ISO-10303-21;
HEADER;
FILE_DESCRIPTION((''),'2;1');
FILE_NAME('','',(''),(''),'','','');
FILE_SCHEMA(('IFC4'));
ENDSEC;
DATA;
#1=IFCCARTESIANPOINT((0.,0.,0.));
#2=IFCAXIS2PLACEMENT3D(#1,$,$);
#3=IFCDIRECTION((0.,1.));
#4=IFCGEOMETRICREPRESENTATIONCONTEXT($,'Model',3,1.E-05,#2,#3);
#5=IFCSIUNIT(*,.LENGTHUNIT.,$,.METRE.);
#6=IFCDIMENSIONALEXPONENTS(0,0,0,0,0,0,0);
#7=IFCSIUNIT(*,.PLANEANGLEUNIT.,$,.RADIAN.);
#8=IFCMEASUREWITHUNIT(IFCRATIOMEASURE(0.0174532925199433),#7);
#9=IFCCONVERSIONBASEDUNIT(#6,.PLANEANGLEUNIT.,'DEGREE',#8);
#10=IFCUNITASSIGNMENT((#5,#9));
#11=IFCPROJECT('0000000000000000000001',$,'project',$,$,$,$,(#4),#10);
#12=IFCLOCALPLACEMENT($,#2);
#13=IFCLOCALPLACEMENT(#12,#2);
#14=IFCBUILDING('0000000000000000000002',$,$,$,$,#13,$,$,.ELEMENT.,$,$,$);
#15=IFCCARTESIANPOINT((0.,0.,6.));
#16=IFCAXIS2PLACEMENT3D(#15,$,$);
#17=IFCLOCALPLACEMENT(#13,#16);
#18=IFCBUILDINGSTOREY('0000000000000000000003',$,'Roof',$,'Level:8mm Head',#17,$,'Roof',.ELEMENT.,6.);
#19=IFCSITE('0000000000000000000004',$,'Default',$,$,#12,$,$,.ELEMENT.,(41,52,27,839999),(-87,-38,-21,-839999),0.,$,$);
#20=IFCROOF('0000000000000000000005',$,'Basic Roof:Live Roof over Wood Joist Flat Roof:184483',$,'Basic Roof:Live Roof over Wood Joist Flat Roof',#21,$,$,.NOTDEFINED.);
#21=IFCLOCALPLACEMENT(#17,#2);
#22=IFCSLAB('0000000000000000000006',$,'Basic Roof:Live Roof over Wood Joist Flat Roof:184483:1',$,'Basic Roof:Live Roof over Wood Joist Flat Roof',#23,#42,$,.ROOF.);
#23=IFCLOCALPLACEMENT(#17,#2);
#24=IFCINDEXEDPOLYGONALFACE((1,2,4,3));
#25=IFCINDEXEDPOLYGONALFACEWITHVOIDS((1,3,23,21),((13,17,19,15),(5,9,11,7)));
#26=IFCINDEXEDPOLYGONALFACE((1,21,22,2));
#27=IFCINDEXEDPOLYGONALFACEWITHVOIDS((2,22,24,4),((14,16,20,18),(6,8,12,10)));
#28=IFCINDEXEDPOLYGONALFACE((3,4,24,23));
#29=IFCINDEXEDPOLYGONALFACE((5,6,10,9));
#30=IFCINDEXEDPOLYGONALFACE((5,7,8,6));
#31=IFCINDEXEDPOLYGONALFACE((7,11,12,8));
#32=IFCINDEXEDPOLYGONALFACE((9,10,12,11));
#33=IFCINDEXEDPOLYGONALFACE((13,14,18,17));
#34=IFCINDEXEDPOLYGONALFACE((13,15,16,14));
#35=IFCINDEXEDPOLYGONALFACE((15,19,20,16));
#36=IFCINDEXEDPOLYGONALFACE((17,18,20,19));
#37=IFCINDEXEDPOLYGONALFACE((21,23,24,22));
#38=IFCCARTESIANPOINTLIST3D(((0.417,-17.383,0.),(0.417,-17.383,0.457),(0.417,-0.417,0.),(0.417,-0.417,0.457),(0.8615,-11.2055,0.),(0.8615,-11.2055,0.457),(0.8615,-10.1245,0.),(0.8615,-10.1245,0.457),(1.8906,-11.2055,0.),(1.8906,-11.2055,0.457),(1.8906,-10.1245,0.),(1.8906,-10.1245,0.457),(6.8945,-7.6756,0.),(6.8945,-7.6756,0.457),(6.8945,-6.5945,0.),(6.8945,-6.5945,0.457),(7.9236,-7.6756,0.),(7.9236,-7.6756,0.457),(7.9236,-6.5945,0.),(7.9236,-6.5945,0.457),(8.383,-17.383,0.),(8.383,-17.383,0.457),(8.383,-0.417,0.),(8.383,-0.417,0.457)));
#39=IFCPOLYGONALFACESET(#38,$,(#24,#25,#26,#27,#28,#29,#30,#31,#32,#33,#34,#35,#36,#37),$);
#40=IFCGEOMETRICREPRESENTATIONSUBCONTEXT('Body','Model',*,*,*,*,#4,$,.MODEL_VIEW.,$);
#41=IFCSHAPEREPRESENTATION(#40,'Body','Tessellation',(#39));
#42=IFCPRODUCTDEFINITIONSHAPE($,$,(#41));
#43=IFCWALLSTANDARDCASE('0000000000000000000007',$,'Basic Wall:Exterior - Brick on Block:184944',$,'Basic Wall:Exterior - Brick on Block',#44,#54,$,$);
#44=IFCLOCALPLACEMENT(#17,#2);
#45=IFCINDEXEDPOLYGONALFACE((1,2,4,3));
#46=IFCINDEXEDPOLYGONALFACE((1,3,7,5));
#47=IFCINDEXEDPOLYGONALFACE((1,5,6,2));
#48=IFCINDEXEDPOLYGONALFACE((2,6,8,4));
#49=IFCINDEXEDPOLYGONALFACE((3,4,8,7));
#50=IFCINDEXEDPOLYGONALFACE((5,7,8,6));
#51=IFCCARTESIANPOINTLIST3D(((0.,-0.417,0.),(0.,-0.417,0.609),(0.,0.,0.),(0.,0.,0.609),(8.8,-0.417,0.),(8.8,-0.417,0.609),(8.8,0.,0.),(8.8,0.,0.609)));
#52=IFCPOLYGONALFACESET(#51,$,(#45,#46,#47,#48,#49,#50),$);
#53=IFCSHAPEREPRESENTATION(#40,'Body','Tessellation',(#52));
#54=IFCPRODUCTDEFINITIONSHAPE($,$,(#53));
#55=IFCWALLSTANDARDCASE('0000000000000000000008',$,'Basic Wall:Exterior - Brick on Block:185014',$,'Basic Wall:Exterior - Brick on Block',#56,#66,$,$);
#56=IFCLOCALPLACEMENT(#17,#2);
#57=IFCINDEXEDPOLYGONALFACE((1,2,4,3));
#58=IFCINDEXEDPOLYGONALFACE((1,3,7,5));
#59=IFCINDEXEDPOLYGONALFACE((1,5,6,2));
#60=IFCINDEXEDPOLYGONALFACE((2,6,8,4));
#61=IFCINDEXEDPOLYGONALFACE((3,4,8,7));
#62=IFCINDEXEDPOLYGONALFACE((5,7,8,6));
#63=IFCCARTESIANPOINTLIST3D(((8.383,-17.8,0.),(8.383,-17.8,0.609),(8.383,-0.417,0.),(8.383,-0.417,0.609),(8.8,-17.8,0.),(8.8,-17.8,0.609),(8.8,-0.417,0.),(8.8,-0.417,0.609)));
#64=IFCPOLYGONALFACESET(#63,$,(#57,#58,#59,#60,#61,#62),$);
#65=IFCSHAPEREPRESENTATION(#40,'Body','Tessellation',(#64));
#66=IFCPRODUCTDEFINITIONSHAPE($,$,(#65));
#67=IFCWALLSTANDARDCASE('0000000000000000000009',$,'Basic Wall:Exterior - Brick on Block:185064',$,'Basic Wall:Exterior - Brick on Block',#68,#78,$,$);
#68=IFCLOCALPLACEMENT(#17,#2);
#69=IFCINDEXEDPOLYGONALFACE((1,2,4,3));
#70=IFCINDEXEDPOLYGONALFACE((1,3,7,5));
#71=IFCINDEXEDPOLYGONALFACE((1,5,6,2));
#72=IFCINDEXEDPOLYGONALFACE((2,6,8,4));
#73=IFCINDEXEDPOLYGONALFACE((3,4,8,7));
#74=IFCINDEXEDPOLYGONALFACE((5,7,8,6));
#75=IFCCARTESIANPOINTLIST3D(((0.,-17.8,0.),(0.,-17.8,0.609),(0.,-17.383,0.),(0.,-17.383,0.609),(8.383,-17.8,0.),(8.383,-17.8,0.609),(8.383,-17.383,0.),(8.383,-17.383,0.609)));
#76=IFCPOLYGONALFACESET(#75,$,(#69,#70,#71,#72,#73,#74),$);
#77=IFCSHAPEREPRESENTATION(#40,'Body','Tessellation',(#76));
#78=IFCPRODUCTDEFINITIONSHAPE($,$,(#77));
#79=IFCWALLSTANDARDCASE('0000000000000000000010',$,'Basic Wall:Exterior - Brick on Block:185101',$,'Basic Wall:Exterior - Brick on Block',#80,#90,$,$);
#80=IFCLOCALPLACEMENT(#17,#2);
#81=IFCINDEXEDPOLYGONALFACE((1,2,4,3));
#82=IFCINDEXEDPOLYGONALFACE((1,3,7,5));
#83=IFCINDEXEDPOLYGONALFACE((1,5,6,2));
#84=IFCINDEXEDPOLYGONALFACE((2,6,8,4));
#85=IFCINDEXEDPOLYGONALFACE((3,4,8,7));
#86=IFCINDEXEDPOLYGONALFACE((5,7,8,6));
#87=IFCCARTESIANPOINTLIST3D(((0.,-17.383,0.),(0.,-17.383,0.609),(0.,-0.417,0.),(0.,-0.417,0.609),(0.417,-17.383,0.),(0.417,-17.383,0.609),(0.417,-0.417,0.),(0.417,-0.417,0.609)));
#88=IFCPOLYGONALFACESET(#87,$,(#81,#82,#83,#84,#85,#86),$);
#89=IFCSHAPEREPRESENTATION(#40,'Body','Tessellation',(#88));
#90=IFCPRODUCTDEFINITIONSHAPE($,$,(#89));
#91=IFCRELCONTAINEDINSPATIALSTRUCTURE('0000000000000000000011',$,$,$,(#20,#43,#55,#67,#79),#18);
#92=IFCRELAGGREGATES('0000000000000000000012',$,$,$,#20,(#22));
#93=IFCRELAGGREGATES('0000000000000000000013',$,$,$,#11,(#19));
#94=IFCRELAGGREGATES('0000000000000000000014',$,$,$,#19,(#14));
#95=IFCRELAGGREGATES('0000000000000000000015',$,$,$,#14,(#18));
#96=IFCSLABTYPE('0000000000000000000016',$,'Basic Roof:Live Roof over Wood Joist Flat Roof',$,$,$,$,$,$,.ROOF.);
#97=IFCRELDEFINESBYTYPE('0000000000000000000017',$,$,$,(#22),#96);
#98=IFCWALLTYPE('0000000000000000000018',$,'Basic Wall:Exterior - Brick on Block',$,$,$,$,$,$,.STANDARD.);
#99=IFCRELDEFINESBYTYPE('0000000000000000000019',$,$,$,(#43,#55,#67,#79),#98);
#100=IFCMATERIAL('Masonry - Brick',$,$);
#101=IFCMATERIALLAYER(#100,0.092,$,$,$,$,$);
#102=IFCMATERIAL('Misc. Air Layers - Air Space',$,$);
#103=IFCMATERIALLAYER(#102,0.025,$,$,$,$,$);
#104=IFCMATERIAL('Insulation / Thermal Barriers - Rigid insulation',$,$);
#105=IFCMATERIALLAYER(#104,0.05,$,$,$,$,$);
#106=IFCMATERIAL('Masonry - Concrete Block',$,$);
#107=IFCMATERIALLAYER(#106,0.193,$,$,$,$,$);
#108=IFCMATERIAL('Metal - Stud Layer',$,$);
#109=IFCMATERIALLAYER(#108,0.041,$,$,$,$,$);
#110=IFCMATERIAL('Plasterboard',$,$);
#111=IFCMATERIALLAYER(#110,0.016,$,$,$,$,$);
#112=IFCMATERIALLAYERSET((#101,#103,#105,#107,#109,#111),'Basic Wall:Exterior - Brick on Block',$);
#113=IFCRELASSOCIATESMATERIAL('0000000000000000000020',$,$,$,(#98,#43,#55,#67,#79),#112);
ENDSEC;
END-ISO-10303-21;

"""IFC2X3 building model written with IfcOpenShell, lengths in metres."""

from ifc_helpers import new_model, entity, si_unit, converted_unit, direction, frame, frame_2d, origin, place, context, subcontext, project, spatial, rectangle, extrude, material, layer, layer_set, layer_usage, type_object, element, aggregate, save


model = new_model("IFC2X3")

# Units and contexts
model_context = context("Model", 3, precision=1e-05, world=origin(), true_north=direction((0.0, 1.0)))
body_context = subcontext(model_context, "Body", "Model", "MODEL_VIEW")
ifc_project = project(units=[si_unit("LENGTHUNIT", "METRE"), converted_unit("PLANEANGLEUNIT", "DEGREE", entity("IfcRatioMeasure", 0.0174532925199433), si_unit("PLANEANGLEUNIT", "RADIAN"), dimensions=[0, 0, 0, 0, 0, 0, 0])], contexts=[model_context])

# Site, building, storey
site_placement = place(None, origin())
site = spatial("IfcSite", under=ifc_project, at=site_placement, Name="Default", CompositionType="ELEMENT", RefLatitude=(41, 52, 27, 839999), RefLongitude=(-87, -38, -21, -839999), RefElevation=0.0)
building_placement = place(site_placement, origin())
building = spatial("IfcBuilding", under=site, at=building_placement, CompositionType="ELEMENT")
storey_placement = place(building_placement, frame((0.0, 0.0, 6.0)))
storey = spatial("IfcBuildingStorey", under=building, at=storey_placement, Name="Roof", ObjectType="Level:8mm Head", LongName="Roof", CompositionType="ELEMENT", Elevation=6.0)

# Roof, slab, openings
roof_placement = place(storey_placement, origin())
roof = element("IfcRoof", 1, at=roof_placement, inside=storey, Name="Basic Roof:Live Roof over Wood Joist Flat Roof:184483", ObjectType="Basic Roof:Live Roof over Wood Joist Flat Roof", ShapeType="NOTDEFINED")
slab_type = type_object("IfcSlabType", Name="Basic Roof:Live Roof over Wood Joist Flat Roof", PredefinedType="ROOF")
slab_placement = place(storey_placement, origin())
slab = element("IfcSlab", 2, at=slab_placement, type_object=slab_type, Name="Basic Roof:Live Roof over Wood Joist Flat Roof:184483:1", ObjectType="Basic Roof:Live Roof over Wood Joist Flat Roof", PredefinedType="ROOF", context=body_context, shape_type="SweptSolid", body=[
    extrude(rectangle(XDim=16.966, YDim=7.966, at=frame_2d((0.0, 0.0), x_axis=(1.0, 0.0))), frame((4.4, -8.9, 0.0), z_axis=(0.0, 0.0, 1.0), x_axis=(0.0, -1.0, 0.0)), (0.0, 0.0, 1.0), 0.457),
])
opening_1_placement = place(storey_placement, origin())
element("IfcOpeningElement", 3, at=opening_1_placement, cuts=slab, ObjectType="Opening", context=body_context, shape_type="SweptSolid", body=[
    extrude(rectangle(XDim=1.0291, YDim=1.0811, at=frame_2d((0.0, 0.0), x_axis=(1.0, 0.0))), frame((1.376, -10.665, 0.0), z_axis=(0.0, 0.0, 1.0), x_axis=(-1.0, 0.0, 0.0)), (0.0, 0.0, 1.0), 0.457),
])
opening_2_placement = place(storey_placement, origin())
element("IfcOpeningElement", 4, at=opening_2_placement, cuts=slab, ObjectType="Opening", context=body_context, shape_type="SweptSolid", body=[
    extrude(rectangle(XDim=1.0291, YDim=1.0811, at=frame_2d((0.0, 0.0), x_axis=(1.0, 0.0))), frame((7.409, -7.135, 0.0), z_axis=(0.0, 0.0, 1.0), x_axis=(-1.0, 0.0, 0.0)), (0.0, 0.0, 1.0), 0.457),
])
aggregate(roof, [slab])

# Walls
ifc_material_1 = material(Name="Masonry - Brick")
ifc_layer_1 = layer(ifc_material_1, 0.092)
ifc_material_2 = material(Name="Misc. Air Layers - Air Space")
ifc_layer_2 = layer(ifc_material_2, 0.025)
ifc_material_3 = material(Name="Insulation / Thermal Barriers - Rigid insulation")
ifc_layer_3 = layer(ifc_material_3, 0.05)
ifc_material_4 = material(Name="Masonry - Concrete Block")
ifc_layer_4 = layer(ifc_material_4, 0.193)
ifc_material_5 = material(Name="Metal - Stud Layer")
ifc_layer_5 = layer(ifc_material_5, 0.041)
ifc_material_6 = material(Name="Plasterboard")
ifc_layer_6 = layer(ifc_material_6, 0.016)
ifc_layer_set = layer_set([ifc_layer_1, ifc_layer_2, ifc_layer_3, ifc_layer_4, ifc_layer_5, ifc_layer_6], Name="Basic Wall:Exterior - Brick on Block")
ifc_layer_usage_1 = layer_usage(ifc_layer_set, "AXIS2", "NEGATIVE", 0.2085)
wall_type = type_object("IfcWallType", Name="Basic Wall:Exterior - Brick on Block", PredefinedType="STANDARD", material=ifc_layer_set)
wall_1_placement = place(storey_placement, frame((0.0, -0.2085, 0.0)))
element("IfcWallStandardCase", 5, at=wall_1_placement, inside=storey, type_object=wall_type, material=ifc_layer_usage_1, Name="Basic Wall:Exterior - Brick on Block:184944", ObjectType="Basic Wall:Exterior - Brick on Block", context=body_context, shape_type="SweptSolid", body=[
    extrude(rectangle(XDim=8.8, YDim=0.417, at=frame_2d((4.4, 0.0), x_axis=(-1.0, 0.0))), origin(), (0.0, 0.0, 1.0), 0.609),
])
ifc_layer_usage_2 = layer_usage(ifc_layer_set, "AXIS2", "NEGATIVE", 0.2085)
wall_2_placement = place(storey_placement, frame((8.5915, -0.417, 0.0), z_axis=(0.0, 0.0, 1.0), x_axis=(0.0, -1.0, 0.0)))
element("IfcWallStandardCase", 6, at=wall_2_placement, inside=storey, type_object=wall_type, material=ifc_layer_usage_2, Name="Basic Wall:Exterior - Brick on Block:185014", ObjectType="Basic Wall:Exterior - Brick on Block", context=body_context, shape_type="SweptSolid", body=[
    extrude(rectangle(XDim=17.383, YDim=0.417, at=frame_2d((8.6915, 0.0), x_axis=(-1.0, 0.0))), origin(), (0.0, 0.0, 1.0), 0.609),
])
ifc_layer_usage_3 = layer_usage(ifc_layer_set, "AXIS2", "NEGATIVE", 0.2085)
wall_3_placement = place(storey_placement, frame((8.383, -17.5915, 0.0), z_axis=(0.0, 0.0, 1.0), x_axis=(-1.0, 0.0, 0.0)))
element("IfcWallStandardCase", 7, at=wall_3_placement, inside=storey, type_object=wall_type, material=ifc_layer_usage_3, Name="Basic Wall:Exterior - Brick on Block:185064", ObjectType="Basic Wall:Exterior - Brick on Block", context=body_context, shape_type="SweptSolid", body=[
    extrude(rectangle(XDim=8.383, YDim=0.417, at=frame_2d((4.1915, 0.0), x_axis=(-1.0, 0.0))), origin(), (0.0, 0.0, 1.0), 0.609),
])
ifc_layer_usage_4 = layer_usage(ifc_layer_set, "AXIS2", "NEGATIVE", 0.2085)
wall_4_placement = place(storey_placement, frame((0.2085, -17.383, 0.0), z_axis=(0.0, 0.0, 1.0), x_axis=(0.0, 1.0, 0.0)))
element("IfcWallStandardCase", 8, at=wall_4_placement, inside=storey, type_object=wall_type, material=ifc_layer_usage_4, Name="Basic Wall:Exterior - Brick on Block:185101", ObjectType="Basic Wall:Exterior - Brick on Block", context=body_context, shape_type="SweptSolid", body=[
    extrude(rectangle(XDim=16.966, YDim=0.417, at=frame_2d((8.483, 0.0), x_axis=(-1.0, 0.0))), origin(), (0.0, 0.0, 1.0), 0.609),
])

save(model, "model.ifc")
